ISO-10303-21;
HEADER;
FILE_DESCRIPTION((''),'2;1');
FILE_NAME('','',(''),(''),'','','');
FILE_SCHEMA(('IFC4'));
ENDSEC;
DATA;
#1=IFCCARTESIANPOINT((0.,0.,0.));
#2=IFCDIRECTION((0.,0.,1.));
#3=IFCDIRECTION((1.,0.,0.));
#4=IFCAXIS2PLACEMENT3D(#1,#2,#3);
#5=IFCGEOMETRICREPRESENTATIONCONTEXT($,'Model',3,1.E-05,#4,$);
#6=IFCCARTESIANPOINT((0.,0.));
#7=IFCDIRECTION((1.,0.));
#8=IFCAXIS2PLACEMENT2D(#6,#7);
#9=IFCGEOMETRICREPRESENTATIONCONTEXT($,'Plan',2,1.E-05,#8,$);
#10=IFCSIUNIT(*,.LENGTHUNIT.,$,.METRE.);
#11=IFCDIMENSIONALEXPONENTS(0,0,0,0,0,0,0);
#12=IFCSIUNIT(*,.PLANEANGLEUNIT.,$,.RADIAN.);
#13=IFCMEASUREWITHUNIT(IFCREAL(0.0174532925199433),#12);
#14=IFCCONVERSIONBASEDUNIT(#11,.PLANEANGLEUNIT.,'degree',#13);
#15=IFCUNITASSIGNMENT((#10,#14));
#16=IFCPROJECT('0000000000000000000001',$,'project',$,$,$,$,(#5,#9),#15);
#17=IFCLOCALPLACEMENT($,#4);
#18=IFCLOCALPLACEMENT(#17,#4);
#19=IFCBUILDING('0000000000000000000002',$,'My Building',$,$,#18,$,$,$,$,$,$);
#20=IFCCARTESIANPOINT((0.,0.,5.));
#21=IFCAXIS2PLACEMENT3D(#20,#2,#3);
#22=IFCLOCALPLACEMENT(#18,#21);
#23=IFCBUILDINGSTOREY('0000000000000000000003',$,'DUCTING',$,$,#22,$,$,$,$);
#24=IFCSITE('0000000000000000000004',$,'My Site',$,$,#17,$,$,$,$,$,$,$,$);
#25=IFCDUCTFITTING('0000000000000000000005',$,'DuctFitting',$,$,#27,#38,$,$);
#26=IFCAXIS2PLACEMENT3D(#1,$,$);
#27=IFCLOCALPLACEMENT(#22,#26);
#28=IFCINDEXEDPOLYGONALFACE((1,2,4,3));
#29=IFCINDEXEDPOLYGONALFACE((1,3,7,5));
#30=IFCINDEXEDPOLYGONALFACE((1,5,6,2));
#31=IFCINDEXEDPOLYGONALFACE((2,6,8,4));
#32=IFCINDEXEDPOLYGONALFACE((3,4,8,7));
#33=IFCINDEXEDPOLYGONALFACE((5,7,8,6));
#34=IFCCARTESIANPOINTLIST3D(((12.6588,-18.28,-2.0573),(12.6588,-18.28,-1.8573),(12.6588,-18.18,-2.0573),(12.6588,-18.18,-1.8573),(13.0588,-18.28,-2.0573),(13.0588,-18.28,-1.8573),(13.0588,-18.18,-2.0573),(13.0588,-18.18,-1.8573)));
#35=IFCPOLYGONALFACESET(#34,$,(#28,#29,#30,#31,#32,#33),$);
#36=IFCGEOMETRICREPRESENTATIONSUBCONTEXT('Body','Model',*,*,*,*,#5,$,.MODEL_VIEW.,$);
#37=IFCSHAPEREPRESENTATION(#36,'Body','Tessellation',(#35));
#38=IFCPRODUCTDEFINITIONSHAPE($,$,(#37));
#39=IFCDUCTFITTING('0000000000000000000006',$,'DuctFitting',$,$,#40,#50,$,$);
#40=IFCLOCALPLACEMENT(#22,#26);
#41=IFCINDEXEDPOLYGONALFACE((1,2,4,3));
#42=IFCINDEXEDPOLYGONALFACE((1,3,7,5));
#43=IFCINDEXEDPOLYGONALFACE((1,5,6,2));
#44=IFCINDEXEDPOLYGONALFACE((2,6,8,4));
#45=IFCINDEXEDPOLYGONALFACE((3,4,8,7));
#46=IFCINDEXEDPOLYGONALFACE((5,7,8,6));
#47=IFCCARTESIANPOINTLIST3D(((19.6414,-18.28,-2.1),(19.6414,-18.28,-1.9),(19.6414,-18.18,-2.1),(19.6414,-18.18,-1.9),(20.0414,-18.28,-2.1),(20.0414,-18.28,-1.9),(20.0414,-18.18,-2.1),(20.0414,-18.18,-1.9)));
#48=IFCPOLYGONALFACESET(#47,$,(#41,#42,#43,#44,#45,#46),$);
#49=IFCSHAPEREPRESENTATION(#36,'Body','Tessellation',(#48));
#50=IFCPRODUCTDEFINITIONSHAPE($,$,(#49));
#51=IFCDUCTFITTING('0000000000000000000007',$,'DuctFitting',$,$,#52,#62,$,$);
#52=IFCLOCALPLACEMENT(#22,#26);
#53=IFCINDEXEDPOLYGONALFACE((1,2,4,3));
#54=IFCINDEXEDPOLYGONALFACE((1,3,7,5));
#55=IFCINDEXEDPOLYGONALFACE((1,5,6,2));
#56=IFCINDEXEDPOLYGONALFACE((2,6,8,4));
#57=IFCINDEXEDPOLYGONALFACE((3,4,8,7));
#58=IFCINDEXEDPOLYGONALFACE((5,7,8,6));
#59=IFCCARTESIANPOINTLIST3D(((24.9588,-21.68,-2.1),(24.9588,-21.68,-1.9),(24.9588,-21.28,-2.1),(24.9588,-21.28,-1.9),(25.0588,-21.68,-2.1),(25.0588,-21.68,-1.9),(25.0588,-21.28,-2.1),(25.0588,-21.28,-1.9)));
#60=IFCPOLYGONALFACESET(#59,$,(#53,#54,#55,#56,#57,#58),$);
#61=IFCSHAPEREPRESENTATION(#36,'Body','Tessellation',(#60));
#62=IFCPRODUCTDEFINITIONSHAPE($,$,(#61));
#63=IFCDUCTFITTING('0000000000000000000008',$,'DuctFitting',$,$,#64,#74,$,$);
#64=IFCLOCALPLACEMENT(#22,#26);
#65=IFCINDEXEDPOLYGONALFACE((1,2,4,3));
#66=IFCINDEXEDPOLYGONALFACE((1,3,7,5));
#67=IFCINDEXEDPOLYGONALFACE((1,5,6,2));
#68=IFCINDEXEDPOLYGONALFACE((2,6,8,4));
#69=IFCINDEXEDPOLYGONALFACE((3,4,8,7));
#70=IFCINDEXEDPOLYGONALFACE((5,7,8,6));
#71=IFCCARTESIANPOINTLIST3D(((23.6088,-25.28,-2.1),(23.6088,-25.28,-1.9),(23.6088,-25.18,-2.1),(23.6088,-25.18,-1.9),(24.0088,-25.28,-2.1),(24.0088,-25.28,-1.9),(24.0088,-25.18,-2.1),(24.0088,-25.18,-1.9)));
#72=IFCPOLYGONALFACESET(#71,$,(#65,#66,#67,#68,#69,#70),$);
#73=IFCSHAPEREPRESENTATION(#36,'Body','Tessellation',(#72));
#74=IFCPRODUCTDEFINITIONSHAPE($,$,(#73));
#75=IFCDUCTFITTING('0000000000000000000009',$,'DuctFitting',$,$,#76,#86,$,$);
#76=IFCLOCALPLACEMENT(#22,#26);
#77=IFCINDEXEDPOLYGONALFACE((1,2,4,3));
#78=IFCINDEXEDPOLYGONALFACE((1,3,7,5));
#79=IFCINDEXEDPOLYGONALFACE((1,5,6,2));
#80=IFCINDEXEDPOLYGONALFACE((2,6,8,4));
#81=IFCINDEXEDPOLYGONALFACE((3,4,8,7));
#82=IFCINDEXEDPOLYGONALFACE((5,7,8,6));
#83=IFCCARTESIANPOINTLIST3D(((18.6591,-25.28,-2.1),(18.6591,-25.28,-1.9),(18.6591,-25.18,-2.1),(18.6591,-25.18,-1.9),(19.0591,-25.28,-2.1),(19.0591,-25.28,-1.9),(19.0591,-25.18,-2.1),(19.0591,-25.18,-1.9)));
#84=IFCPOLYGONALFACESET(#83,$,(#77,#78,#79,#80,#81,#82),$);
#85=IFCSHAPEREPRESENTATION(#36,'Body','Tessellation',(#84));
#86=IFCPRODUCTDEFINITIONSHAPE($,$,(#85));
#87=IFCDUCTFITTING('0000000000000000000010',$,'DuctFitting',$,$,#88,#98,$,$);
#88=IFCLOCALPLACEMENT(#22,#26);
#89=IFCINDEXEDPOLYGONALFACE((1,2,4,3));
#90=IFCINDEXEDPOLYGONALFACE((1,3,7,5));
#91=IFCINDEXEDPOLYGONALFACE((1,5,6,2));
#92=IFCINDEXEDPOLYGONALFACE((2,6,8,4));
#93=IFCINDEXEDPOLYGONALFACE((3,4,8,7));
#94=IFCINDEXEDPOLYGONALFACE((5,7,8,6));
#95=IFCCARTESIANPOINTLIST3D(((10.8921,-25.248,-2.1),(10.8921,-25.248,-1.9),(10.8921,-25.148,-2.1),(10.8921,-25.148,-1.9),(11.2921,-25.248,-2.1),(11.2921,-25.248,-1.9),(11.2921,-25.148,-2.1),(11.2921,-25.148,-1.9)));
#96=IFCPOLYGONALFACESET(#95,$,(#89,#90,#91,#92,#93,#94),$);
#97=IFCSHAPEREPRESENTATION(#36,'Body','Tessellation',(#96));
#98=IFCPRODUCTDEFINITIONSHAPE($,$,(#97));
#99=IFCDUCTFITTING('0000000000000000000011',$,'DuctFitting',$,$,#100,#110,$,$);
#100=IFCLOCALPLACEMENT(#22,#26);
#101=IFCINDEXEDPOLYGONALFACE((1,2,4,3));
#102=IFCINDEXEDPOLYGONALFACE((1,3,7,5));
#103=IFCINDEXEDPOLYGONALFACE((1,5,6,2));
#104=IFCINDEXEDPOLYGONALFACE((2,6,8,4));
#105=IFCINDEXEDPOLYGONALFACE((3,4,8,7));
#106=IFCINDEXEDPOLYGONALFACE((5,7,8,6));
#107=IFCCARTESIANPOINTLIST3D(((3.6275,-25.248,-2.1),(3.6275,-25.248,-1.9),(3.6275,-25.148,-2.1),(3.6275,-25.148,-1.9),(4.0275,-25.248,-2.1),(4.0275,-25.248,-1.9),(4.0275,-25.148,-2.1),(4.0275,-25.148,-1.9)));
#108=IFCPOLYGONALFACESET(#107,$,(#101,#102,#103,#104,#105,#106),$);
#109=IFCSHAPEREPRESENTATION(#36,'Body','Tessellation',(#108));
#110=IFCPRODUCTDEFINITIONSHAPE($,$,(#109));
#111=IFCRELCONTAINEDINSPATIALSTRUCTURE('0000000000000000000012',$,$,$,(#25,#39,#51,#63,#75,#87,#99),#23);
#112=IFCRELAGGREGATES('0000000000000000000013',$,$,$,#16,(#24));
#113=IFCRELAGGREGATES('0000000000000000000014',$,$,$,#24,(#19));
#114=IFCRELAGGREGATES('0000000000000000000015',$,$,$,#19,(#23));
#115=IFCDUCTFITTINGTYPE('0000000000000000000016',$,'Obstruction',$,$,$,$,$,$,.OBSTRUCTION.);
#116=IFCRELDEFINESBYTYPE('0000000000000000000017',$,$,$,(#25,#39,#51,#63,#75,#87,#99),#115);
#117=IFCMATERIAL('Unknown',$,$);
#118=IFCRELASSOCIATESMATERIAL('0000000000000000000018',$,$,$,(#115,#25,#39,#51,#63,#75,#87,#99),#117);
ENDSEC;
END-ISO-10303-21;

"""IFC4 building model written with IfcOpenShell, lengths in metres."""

from ifc_helpers import new_model, entity, si_unit, converted_unit, frame, origin_with_axes, origin_2d_with_axis, place, context, subcontext, project, spatial, rectangle, extrude, material, material_profile, profile_set, profile_usage, type_object, element, save


model = new_model("IFC4")

# Units and contexts
model_context = context("Model", 3, precision=1e-05, world=origin_with_axes())
plan_context = context("Plan", 2, precision=1e-05, world=origin_2d_with_axis())
body_context = subcontext(model_context, "Body", "Model", "MODEL_VIEW")
ifc_project = project(units=[si_unit("LENGTHUNIT", "METRE"), converted_unit("PLANEANGLEUNIT", "degree", entity("IfcReal", 0.0174532925199433), si_unit("PLANEANGLEUNIT", "RADIAN"), dimensions=[0, 0, 0, 0, 0, 0, 0])], contexts=[model_context, plan_context])

# Site, building, storey
site_placement = place(None, origin_with_axes())
site = spatial("IfcSite", under=ifc_project, at=site_placement, Name="My Site")
building_placement = place(site_placement, origin_with_axes())
building = spatial("IfcBuilding", under=site, at=building_placement, Name="My Building")
storey_placement = place(building_placement, frame((0.0, 0.0, 5.0), z_axis=(0.0, 0.0, 1.0), x_axis=(1.0, 0.0, 0.0)))
storey = spatial("IfcBuildingStorey", under=building, at=storey_placement, Name="DUCTING")

# Shared definitions
ifc_material = material(Name="Unknown")

# Duct fittings
ifc_material_profile_1 = material_profile(ifc_material, rectangle(XDim=0.4, YDim=0.2))
ifc_profile_set_1 = profile_set([ifc_material_profile_1])
duct_fitting_type_1 = type_object("IfcDuctFittingType", Name="Obstruction", PredefinedType="OBSTRUCTION", material=ifc_profile_set_1)
ifc_profile_usage_1 = profile_usage(ifc_profile_set_1, cardinal=5)
duct_fitting_1_placement = place(storey_placement, frame((12.8588, -18.28, -1.9573), z_axis=(0.0, 1.0, 0.000001), x_axis=(-1.0, 0.0, 0.0)))
element("IfcDuctFitting", 1, at=duct_fitting_1_placement, inside=storey, type_object=duct_fitting_type_1, material=ifc_profile_usage_1, Name="DuctFitting", context=body_context, shape_type="SweptSolid", body=[
    extrude(rectangle(XDim=0.4, YDim=0.2), origin_with_axes(), (0.0, 0.0, 1.0), 0.1),
])
ifc_profile_usage_2 = profile_usage(ifc_profile_set_1, cardinal=5)
duct_fitting_2_placement = place(storey_placement, frame((19.8414, -18.28, -2.0), z_axis=(0.0, 1.0, 0.000001), x_axis=(-1.0, 0.0, 0.0)))
element("IfcDuctFitting", 2, at=duct_fitting_2_placement, inside=storey, type_object=duct_fitting_type_1, material=ifc_profile_usage_2, Name="DuctFitting", context=body_context, shape_type="SweptSolid", body=[
    extrude(rectangle(XDim=0.4, YDim=0.2), origin_with_axes(), (0.0, 0.0, 1.0), 0.1),
])
ifc_profile_usage_3 = profile_usage(ifc_profile_set_1, cardinal=5)
duct_fitting_3_placement = place(storey_placement, frame((25.0588, -21.48, -2.0), z_axis=(-1.0, -0.000001, 0.000001), x_axis=(0.000001, -1.0, 0.0)))
element("IfcDuctFitting", 3, at=duct_fitting_3_placement, inside=storey, type_object=duct_fitting_type_1, material=ifc_profile_usage_3, Name="DuctFitting", context=body_context, shape_type="SweptSolid", body=[
    extrude(rectangle(XDim=0.4, YDim=0.2), origin_with_axes(), (0.0, 0.0, 1.0), 0.1),
])
ifc_profile_usage_4 = profile_usage(ifc_profile_set_1, cardinal=5)
duct_fitting_4_placement = place(storey_placement, frame((23.8088, -25.18, -2.0), z_axis=(0.0, -1.0, 0.000002), x_axis=(1.0, 0.0, 0.0)))
element("IfcDuctFitting", 4, at=duct_fitting_4_placement, inside=storey, type_object=duct_fitting_type_1, material=ifc_profile_usage_4, Name="DuctFitting", context=body_context, shape_type="SweptSolid", body=[
    extrude(rectangle(XDim=0.4, YDim=0.2), origin_with_axes(), (0.0, 0.0, 1.0), 0.1),
])
ifc_profile_usage_5 = profile_usage(ifc_profile_set_1, cardinal=5)
duct_fitting_5_placement = place(storey_placement, frame((18.8591, -25.18, -2.0), z_axis=(0.0, -1.0, 0.000002), x_axis=(1.0, 0.0, 0.0)))
element("IfcDuctFitting", 5, at=duct_fitting_5_placement, inside=storey, type_object=duct_fitting_type_1, material=ifc_profile_usage_5, Name="DuctFitting", context=body_context, shape_type="SweptSolid", body=[
    extrude(rectangle(XDim=0.4, YDim=0.2), origin_with_axes(), (0.0, 0.0, 1.0), 0.1),
])
ifc_profile_usage_6 = profile_usage(ifc_profile_set_1, cardinal=5)
duct_fitting_6_placement = place(storey_placement, frame((11.0921, -25.148, -2.0), z_axis=(0.0, -1.0, 0.000002), x_axis=(1.0, 0.0, 0.0)))
element("IfcDuctFitting", 6, at=duct_fitting_6_placement, inside=storey, type_object=duct_fitting_type_1, material=ifc_profile_usage_6, Name="DuctFitting", context=body_context, shape_type="SweptSolid", body=[
    extrude(rectangle(XDim=0.4, YDim=0.2), origin_with_axes(), (0.0, 0.0, 1.0), 0.1),
])
ifc_profile_usage_7 = profile_usage(ifc_profile_set_1, cardinal=5)
duct_fitting_7_placement = place(storey_placement, frame((3.8275, -25.148, -2.0), z_axis=(0.0, -1.0, 0.000002), x_axis=(1.0, 0.0, 0.0)))
element("IfcDuctFitting", 7, at=duct_fitting_7_placement, inside=storey, type_object=duct_fitting_type_1, material=ifc_profile_usage_7, Name="DuctFitting", context=body_context, shape_type="SweptSolid", body=[
    extrude(rectangle(XDim=0.4, YDim=0.2), origin_with_axes(), (0.0, 0.0, 1.0), 0.1),
])

save(model, "model.ifc")
